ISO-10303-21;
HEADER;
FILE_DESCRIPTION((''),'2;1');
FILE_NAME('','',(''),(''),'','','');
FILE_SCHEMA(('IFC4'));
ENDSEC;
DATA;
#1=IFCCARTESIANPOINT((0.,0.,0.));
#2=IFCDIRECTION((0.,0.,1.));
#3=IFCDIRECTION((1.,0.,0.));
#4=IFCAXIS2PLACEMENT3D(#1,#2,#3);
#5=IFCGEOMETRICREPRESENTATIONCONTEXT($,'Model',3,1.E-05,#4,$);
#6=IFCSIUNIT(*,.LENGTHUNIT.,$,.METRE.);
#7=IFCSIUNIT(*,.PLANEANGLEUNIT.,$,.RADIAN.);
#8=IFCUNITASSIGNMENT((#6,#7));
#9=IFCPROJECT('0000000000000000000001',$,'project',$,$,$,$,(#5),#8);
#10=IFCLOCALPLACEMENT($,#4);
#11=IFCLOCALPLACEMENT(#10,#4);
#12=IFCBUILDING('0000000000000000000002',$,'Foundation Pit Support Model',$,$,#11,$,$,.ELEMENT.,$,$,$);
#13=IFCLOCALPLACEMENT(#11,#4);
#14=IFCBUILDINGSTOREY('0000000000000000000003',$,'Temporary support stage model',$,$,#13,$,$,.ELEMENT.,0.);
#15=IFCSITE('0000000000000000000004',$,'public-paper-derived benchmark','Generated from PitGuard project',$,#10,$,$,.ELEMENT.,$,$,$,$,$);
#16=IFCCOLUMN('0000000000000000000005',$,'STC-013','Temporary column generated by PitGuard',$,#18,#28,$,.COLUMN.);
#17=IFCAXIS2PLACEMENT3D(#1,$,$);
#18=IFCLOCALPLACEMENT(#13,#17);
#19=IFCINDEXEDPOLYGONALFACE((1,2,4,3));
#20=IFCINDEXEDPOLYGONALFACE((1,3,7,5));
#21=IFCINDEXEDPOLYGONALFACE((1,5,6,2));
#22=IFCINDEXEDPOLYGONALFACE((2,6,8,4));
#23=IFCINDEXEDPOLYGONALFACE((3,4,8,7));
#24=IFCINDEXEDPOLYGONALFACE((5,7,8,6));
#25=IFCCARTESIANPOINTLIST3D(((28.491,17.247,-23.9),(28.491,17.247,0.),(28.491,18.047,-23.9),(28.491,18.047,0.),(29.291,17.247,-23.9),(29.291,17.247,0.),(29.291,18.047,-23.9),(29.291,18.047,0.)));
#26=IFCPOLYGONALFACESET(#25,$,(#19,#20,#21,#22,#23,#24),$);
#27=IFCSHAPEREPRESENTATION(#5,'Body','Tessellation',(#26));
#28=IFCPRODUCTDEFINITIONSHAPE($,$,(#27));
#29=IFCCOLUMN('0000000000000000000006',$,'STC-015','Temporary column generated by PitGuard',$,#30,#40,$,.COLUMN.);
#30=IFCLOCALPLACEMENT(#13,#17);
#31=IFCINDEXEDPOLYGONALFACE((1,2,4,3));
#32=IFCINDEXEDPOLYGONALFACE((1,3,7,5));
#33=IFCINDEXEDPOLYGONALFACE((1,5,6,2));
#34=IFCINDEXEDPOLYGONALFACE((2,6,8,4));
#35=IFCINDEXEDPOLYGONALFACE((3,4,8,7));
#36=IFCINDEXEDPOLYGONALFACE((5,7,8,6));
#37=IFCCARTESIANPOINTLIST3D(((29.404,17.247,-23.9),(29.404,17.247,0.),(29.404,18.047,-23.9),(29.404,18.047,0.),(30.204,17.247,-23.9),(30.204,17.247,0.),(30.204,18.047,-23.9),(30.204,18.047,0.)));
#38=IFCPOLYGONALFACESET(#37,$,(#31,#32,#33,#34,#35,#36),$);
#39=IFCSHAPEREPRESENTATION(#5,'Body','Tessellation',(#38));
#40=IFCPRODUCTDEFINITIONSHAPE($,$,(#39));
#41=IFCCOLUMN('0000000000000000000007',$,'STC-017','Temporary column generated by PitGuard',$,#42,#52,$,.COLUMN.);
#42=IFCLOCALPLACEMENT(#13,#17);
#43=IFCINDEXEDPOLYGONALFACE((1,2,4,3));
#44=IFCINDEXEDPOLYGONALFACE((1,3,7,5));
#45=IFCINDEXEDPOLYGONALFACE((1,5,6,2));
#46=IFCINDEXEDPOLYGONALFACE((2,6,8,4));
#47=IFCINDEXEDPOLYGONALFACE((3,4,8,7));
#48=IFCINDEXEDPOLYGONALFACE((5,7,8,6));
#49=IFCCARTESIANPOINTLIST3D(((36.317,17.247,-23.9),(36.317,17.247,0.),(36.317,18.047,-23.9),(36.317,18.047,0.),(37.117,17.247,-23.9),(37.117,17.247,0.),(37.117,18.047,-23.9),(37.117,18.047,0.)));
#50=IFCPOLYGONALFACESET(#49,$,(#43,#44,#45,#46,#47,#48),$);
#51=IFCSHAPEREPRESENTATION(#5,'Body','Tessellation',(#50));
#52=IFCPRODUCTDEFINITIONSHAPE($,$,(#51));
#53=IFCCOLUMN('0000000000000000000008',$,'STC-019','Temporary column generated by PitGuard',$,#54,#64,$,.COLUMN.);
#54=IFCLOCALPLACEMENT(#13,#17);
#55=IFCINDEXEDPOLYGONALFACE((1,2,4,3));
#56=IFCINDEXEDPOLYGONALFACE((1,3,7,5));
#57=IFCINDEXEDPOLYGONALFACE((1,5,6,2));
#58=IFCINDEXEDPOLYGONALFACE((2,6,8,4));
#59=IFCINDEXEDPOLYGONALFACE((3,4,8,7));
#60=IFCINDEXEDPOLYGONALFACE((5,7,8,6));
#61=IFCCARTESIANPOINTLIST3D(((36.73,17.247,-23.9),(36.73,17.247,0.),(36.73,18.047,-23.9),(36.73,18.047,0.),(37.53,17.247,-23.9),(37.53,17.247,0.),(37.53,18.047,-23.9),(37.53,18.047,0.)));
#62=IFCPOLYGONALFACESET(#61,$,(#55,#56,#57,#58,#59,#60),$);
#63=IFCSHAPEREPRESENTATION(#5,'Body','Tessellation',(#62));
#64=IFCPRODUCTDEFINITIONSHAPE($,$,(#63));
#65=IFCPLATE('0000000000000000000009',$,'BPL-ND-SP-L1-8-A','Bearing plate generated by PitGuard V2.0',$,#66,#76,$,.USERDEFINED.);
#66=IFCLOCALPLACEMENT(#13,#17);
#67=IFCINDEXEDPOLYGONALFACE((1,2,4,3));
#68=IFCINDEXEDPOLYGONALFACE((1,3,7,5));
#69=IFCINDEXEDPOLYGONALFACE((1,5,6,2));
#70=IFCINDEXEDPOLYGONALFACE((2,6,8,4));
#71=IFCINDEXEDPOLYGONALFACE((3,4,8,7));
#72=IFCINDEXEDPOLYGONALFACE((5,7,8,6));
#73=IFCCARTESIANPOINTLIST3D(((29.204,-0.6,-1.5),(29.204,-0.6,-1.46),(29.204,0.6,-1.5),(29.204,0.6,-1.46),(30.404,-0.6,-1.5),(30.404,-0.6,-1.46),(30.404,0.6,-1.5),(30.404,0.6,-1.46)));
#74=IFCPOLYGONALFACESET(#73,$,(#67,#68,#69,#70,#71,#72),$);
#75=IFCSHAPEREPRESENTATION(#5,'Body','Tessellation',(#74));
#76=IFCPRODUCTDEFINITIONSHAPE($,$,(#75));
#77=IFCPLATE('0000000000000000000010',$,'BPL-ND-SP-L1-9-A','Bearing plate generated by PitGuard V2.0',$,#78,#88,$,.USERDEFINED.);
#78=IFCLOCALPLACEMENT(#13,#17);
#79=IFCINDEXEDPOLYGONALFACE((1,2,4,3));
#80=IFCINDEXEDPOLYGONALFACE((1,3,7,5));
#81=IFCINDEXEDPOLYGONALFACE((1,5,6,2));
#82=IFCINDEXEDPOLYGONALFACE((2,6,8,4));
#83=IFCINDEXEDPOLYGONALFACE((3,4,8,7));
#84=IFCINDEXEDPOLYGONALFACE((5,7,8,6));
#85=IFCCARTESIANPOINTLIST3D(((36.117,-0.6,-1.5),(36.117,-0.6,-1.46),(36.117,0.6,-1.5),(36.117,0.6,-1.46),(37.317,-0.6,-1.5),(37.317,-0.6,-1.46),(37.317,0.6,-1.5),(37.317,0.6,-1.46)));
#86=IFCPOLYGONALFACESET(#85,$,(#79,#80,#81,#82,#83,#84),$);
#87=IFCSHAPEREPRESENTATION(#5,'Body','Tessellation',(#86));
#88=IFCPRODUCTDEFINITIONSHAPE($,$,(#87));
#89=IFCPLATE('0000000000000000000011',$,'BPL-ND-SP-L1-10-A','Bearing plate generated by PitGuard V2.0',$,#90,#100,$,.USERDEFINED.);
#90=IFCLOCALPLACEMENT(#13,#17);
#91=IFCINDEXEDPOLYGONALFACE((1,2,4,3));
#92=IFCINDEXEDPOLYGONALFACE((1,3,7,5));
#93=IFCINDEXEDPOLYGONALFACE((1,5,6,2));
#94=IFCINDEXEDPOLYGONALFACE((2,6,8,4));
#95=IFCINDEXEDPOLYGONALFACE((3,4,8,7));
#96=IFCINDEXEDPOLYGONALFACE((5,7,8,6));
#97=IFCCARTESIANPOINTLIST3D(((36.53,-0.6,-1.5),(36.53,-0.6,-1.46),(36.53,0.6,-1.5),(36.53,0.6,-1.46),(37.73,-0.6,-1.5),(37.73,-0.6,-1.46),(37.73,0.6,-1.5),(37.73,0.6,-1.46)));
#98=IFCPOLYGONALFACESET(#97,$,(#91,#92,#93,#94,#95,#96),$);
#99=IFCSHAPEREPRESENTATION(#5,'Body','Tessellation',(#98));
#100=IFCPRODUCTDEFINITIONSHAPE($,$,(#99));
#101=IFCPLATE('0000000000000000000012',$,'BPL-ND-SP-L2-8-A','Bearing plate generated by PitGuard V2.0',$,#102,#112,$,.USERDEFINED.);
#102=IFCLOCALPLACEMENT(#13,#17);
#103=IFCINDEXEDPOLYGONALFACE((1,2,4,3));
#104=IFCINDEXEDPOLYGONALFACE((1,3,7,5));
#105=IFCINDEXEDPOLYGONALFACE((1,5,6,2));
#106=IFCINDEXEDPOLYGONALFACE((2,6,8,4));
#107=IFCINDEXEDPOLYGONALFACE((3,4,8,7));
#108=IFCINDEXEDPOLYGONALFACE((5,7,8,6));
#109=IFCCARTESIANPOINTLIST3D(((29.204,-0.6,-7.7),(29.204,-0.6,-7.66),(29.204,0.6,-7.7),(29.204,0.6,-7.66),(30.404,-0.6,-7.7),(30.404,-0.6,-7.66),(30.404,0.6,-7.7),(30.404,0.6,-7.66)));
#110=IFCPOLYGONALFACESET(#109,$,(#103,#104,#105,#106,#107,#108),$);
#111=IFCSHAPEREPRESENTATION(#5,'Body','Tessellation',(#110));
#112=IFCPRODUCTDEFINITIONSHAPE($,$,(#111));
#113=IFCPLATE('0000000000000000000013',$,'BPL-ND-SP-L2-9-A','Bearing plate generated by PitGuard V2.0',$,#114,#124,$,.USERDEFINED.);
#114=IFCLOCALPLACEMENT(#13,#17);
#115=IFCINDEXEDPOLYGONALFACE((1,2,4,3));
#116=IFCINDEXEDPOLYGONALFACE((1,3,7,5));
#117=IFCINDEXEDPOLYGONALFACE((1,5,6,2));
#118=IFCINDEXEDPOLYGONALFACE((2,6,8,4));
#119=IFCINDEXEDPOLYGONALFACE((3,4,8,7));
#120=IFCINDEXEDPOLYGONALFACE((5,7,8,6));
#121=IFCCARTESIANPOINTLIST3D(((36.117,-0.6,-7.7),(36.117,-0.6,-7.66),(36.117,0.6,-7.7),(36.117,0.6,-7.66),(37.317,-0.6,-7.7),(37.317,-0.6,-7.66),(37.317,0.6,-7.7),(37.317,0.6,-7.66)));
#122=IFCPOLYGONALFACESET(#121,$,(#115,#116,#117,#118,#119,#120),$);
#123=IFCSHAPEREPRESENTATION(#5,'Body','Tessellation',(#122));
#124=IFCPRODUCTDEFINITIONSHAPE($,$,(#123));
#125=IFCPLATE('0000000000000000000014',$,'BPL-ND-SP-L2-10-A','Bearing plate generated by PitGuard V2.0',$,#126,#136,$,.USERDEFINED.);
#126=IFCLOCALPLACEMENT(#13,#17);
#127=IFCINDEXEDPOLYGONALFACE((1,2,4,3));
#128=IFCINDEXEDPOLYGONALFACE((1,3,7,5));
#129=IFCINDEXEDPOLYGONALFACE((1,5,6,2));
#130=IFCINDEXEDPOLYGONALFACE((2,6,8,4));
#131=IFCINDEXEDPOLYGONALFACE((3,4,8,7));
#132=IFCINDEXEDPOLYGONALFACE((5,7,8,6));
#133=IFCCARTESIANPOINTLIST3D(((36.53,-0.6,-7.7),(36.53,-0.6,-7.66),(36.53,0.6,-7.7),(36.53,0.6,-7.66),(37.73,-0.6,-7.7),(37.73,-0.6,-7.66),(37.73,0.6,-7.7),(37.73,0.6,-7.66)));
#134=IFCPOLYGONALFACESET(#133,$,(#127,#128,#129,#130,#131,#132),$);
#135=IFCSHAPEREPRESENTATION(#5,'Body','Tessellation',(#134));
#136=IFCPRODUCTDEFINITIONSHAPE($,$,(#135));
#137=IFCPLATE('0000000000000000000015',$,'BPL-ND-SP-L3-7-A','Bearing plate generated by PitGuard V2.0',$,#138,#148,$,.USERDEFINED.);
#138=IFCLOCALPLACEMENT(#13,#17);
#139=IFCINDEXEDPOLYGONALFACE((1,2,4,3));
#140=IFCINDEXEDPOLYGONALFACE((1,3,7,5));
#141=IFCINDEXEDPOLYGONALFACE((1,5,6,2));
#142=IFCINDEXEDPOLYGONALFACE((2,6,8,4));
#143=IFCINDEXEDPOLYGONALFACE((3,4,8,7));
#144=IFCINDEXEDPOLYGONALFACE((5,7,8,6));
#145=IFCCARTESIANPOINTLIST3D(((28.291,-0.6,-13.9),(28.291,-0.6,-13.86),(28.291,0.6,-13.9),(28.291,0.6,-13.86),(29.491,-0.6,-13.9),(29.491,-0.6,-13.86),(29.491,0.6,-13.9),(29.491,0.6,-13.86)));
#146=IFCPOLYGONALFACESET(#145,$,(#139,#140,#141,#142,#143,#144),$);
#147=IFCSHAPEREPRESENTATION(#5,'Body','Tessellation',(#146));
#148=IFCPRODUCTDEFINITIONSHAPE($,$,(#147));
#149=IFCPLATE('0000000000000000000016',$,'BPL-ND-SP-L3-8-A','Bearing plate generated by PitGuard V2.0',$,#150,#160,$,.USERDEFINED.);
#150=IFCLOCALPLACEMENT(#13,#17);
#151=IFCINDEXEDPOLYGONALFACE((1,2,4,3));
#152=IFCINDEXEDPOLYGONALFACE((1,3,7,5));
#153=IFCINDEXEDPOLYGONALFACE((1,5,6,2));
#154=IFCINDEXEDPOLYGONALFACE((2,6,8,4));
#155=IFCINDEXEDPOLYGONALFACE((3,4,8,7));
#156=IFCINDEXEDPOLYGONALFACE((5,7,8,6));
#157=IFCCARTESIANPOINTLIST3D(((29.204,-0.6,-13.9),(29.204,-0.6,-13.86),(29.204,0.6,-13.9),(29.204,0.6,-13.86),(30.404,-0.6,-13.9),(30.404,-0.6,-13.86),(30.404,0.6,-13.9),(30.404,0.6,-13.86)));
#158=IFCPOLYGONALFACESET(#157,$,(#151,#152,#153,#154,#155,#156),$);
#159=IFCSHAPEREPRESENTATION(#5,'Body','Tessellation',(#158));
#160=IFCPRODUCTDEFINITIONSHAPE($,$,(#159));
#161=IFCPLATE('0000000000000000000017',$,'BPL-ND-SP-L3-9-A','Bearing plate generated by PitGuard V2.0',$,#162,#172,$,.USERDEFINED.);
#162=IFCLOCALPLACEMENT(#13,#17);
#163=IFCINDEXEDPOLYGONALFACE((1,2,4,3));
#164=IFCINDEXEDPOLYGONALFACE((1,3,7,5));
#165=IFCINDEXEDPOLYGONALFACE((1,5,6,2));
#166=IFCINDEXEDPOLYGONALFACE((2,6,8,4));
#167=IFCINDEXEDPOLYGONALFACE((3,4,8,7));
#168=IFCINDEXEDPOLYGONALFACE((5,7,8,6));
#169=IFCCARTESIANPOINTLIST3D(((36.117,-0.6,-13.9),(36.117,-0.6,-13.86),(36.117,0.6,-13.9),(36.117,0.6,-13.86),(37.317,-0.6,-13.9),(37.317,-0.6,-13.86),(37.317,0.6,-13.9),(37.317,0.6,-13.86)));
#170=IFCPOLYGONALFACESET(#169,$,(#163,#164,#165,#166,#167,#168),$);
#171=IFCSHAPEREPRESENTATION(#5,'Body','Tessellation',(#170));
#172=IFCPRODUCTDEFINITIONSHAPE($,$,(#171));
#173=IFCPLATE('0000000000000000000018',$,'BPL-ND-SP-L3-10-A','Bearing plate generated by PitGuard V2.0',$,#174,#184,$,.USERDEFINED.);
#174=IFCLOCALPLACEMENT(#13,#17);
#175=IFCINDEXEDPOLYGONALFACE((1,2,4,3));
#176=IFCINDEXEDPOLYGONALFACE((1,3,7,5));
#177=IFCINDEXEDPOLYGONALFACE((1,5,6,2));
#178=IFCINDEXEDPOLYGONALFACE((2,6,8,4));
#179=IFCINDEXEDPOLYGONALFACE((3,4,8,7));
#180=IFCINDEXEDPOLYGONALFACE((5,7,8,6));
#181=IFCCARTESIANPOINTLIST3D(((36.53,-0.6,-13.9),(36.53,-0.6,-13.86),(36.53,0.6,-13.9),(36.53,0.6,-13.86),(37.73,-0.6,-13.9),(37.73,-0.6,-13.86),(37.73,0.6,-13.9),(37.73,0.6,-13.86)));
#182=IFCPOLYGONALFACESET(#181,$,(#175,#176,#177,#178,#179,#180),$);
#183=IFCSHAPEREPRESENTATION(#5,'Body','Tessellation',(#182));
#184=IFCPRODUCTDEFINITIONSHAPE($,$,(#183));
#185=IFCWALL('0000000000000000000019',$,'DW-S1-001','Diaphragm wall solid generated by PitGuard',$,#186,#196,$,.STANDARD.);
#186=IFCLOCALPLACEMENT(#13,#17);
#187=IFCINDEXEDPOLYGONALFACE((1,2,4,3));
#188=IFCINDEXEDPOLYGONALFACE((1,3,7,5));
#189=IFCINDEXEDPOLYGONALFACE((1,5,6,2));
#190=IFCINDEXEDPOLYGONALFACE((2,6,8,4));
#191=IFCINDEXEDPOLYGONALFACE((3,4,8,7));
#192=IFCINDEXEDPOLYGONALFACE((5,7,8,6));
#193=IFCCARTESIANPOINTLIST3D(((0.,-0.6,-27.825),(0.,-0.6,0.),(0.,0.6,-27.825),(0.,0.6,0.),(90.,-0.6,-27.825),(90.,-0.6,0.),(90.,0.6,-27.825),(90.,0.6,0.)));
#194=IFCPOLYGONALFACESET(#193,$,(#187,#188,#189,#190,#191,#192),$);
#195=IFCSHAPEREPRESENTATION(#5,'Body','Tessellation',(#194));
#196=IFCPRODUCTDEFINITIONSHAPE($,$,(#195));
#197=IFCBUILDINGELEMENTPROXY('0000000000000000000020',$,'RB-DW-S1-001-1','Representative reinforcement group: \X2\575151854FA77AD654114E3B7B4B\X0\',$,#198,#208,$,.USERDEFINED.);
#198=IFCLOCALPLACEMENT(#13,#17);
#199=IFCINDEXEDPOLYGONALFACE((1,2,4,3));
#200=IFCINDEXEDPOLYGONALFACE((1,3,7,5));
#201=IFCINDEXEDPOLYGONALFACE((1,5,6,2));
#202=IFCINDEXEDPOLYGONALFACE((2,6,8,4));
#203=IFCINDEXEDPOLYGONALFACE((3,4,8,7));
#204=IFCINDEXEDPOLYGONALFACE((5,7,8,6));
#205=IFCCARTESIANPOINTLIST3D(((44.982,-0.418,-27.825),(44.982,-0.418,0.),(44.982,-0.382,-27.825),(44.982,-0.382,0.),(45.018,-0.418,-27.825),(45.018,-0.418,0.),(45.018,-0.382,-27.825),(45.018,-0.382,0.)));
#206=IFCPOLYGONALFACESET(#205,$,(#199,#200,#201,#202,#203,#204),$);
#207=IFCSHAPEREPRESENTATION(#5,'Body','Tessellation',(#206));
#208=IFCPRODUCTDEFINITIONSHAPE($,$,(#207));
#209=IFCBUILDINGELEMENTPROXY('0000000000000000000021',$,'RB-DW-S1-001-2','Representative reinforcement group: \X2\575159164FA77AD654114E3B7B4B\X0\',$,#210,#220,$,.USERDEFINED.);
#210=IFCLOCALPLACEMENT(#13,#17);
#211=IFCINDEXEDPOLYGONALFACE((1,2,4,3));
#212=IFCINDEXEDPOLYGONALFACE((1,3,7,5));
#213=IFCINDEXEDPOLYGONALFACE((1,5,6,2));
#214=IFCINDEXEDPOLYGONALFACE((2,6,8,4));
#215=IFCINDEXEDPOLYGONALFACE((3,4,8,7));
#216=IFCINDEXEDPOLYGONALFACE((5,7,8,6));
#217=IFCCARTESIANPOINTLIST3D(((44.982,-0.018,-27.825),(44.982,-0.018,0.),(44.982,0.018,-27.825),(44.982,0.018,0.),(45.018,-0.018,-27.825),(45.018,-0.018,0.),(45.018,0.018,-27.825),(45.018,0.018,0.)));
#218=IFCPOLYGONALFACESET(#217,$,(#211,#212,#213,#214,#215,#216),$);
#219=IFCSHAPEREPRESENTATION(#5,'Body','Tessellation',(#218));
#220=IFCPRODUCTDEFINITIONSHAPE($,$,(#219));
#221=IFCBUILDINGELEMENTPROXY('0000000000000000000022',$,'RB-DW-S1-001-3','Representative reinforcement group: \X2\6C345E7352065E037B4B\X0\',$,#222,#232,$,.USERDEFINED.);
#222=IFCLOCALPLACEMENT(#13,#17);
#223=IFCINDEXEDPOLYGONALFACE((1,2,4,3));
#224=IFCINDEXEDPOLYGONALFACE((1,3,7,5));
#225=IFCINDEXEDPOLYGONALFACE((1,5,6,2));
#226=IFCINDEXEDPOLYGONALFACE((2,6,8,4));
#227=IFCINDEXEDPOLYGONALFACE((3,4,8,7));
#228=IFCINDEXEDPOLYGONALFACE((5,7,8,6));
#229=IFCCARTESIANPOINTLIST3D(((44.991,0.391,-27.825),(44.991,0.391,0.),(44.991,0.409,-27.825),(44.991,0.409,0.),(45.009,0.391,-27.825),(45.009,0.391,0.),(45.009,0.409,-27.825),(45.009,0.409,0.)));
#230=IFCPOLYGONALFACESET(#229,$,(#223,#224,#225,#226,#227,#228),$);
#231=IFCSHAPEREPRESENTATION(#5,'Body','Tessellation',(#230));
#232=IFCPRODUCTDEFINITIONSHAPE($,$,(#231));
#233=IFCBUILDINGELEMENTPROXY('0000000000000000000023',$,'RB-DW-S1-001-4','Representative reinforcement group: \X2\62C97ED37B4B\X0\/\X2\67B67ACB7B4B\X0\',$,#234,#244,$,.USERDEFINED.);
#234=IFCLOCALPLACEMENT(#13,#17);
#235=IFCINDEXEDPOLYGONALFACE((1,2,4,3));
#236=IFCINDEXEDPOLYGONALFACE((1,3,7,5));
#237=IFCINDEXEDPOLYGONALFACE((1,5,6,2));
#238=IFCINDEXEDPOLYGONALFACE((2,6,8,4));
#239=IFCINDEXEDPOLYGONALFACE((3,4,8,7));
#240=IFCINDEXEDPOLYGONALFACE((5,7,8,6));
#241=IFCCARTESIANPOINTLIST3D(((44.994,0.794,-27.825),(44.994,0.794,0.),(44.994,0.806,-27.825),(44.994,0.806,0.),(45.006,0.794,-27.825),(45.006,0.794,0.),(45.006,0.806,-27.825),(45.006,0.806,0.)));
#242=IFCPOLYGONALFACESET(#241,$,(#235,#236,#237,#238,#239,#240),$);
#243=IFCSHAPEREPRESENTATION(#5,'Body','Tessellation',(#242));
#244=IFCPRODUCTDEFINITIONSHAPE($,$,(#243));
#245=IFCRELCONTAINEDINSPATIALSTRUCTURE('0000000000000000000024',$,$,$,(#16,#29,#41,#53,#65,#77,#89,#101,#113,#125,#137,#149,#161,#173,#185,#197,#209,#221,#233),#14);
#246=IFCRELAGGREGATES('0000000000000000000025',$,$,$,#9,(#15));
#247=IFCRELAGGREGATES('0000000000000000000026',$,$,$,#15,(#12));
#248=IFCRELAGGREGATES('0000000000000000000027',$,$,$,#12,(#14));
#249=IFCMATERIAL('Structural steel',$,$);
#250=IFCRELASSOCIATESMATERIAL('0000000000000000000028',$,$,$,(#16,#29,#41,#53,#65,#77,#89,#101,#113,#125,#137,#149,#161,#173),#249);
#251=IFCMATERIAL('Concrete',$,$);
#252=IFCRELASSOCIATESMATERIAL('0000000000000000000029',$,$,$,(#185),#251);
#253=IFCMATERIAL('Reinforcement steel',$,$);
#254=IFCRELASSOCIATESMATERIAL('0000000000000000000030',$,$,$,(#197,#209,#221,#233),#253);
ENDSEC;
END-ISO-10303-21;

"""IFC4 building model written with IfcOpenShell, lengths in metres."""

from ifc_helpers import new_model, si_unit, frame, origin_with_axes, origin_2d, place, context, project, spatial, rectangle, extrude, material, element, save


model = new_model("IFC4")

# Units and contexts
model_context = context("Model", 3, precision=1e-05, world=origin_with_axes())
ifc_project = project(units=[si_unit("LENGTHUNIT", "METRE"), si_unit("PLANEANGLEUNIT", "RADIAN")], contexts=[model_context])

# Site, building, storey
site_placement = place(None, origin_with_axes())
site = spatial("IfcSite", under=ifc_project, at=site_placement, Name="public-paper-derived benchmark", Description="Generated from PitGuard project", CompositionType="ELEMENT")
building_placement = place(site_placement, origin_with_axes())
building = spatial("IfcBuilding", under=site, at=building_placement, Name="Foundation Pit Support Model", CompositionType="ELEMENT")
storey_placement = place(building_placement, origin_with_axes())
storey = spatial("IfcBuildingStorey", under=building, at=storey_placement, Name="Temporary support stage model", CompositionType="ELEMENT", Elevation=0.0)

# Columns
ifc_material_1 = material(Name="Structural steel")
for number, where, z_axis, x_axis, name in (
    (1, (28.891, 17.647, -23.9), (0.0, 0.0, 1.0), (1.0, 0.0, 0.0), "STC-013"),
    (2, (29.804, 17.647, -23.9), (0.0, 0.0, 1.0), (1.0, 0.0, 0.0), "STC-015"),
    (3, (36.717, 17.647, -23.9), (0.0, 0.0, 1.0), (1.0, 0.0, 0.0), "STC-017"),
    (4, (37.13, 17.647, -23.9), (0.0, 0.0, 1.0), (1.0, 0.0, 0.0), "STC-019"),
):
    element("IfcColumn", number, at=place(storey_placement, frame(where, z_axis=z_axis, x_axis=x_axis)), inside=storey, material=ifc_material_1, Name=name, Description="Temporary column generated by PitGuard", PredefinedType="COLUMN", context=model_context, shape_type="SweptSolid", body=[
        extrude(rectangle(XDim=0.8, YDim=0.8, at=origin_2d()), origin_with_axes(), (0.0, 0.0, 1.0), 23.9),
    ])

# Plates
for number, where, z_axis, x_axis, name in (
    (5, (29.804, 0.0, -1.5), (0.0, 0.0, 1.0), (1.0, 0.0, 0.0), "BPL-ND-SP-L1-8-A"),
    (6, (36.717, 0.0, -1.5), (0.0, 0.0, 1.0), (1.0, 0.0, 0.0), "BPL-ND-SP-L1-9-A"),
    (7, (37.13, 0.0, -1.5), (0.0, 0.0, 1.0), (1.0, 0.0, 0.0), "BPL-ND-SP-L1-10-A"),
    (8, (29.804, 0.0, -7.7), (0.0, 0.0, 1.0), (1.0, 0.0, 0.0), "BPL-ND-SP-L2-8-A"),
    (9, (36.717, 0.0, -7.7), (0.0, 0.0, 1.0), (1.0, 0.0, 0.0), "BPL-ND-SP-L2-9-A"),
    (10, (37.13, 0.0, -7.7), (0.0, 0.0, 1.0), (1.0, 0.0, 0.0), "BPL-ND-SP-L2-10-A"),
    (11, (28.891, 0.0, -13.9), (0.0, 0.0, 1.0), (1.0, 0.0, 0.0), "BPL-ND-SP-L3-7-A"),
    (12, (29.804, 0.0, -13.9), (0.0, 0.0, 1.0), (1.0, 0.0, 0.0), "BPL-ND-SP-L3-8-A"),
    (13, (36.717, 0.0, -13.9), (0.0, 0.0, 1.0), (1.0, 0.0, 0.0), "BPL-ND-SP-L3-9-A"),
    (14, (37.13, 0.0, -13.9), (0.0, 0.0, 1.0), (1.0, 0.0, 0.0), "BPL-ND-SP-L3-10-A"),
):
    element("IfcPlate", number, at=place(storey_placement, frame(where, z_axis=z_axis, x_axis=x_axis)), inside=storey, material=ifc_material_1, Name=name, Description="Bearing plate generated by PitGuard V2.0", PredefinedType="USERDEFINED", context=model_context, shape_type="SweptSolid", body=[
        extrude(rectangle(XDim=1.2, YDim=1.2, at=origin_2d()), origin_with_axes(), (0.0, 0.0, 1.0), 0.04),
    ])

# Wall
ifc_material_2 = material(Name="Concrete")
wall_placement = place(storey_placement, frame((45.0, 0.0, -27.825), z_axis=(0.0, 0.0, 1.0), x_axis=(1.0, 0.0, 0.0)))
element("IfcWall", 15, at=wall_placement, inside=storey, material=ifc_material_2, Name="DW-S1-001", Description="Diaphragm wall solid generated by PitGuard", PredefinedType="STANDARD", context=model_context, shape_type="SweptSolid", body=[
    extrude(rectangle(XDim=90.0, YDim=1.2, at=origin_2d()), origin_with_axes(), (0.0, 0.0, 1.0), 27.825),
])

# Building element proxies
ifc_material_3 = material(Name="Reinforcement steel")
for number, where, z_axis, x_axis, name, description in (
    (16, (45.0, -0.4, -27.825), (0.0, 0.0, 1.0), (1.0, 0.0, 0.0), "RB-DW-S1-001-1", "Representative reinforcement group: 坑内侧竖向主筋"),
    (17, (45.0, 0.0, -27.825), (0.0, 0.0, 1.0), (1.0, 0.0, 0.0), "RB-DW-S1-001-2", "Representative reinforcement group: 坑外侧竖向主筋"),
):
    element("IfcBuildingElementProxy", number, at=place(storey_placement, frame(where, z_axis=z_axis, x_axis=x_axis)), inside=storey, material=ifc_material_3, Name=name, Description=description, PredefinedType="USERDEFINED", context=model_context, shape_type="SweptSolid", body=[
        extrude(rectangle(XDim=0.036, YDim=0.036, at=origin_2d()), origin_with_axes(), (0.0, 0.0, 1.0), 27.825),
    ])
proxy_1_placement = place(storey_placement, frame((45.0, 0.4, -27.825), z_axis=(0.0, 0.0, 1.0), x_axis=(1.0, 0.0, 0.0)))
element("IfcBuildingElementProxy", 18, at=proxy_1_placement, inside=storey, material=ifc_material_3, Name="RB-DW-S1-001-3", Description="Representative reinforcement group: 水平分布筋", PredefinedType="USERDEFINED", context=model_context, shape_type="SweptSolid", body=[
    extrude(rectangle(XDim=0.018, YDim=0.018, at=origin_2d()), origin_with_axes(), (0.0, 0.0, 1.0), 27.825),
])
proxy_2_placement = place(storey_placement, frame((45.0, 0.8, -27.825), z_axis=(0.0, 0.0, 1.0), x_axis=(1.0, 0.0, 0.0)))
element("IfcBuildingElementProxy", 19, at=proxy_2_placement, inside=storey, material=ifc_material_3, Name="RB-DW-S1-001-4", Description="Representative reinforcement group: 拉结筋/架立筋", PredefinedType="USERDEFINED", context=model_context, shape_type="SweptSolid", body=[
    extrude(rectangle(XDim=0.012, YDim=0.012, at=origin_2d()), origin_with_axes(), (0.0, 0.0, 1.0), 27.825),
])

save(model, "model.ifc")
